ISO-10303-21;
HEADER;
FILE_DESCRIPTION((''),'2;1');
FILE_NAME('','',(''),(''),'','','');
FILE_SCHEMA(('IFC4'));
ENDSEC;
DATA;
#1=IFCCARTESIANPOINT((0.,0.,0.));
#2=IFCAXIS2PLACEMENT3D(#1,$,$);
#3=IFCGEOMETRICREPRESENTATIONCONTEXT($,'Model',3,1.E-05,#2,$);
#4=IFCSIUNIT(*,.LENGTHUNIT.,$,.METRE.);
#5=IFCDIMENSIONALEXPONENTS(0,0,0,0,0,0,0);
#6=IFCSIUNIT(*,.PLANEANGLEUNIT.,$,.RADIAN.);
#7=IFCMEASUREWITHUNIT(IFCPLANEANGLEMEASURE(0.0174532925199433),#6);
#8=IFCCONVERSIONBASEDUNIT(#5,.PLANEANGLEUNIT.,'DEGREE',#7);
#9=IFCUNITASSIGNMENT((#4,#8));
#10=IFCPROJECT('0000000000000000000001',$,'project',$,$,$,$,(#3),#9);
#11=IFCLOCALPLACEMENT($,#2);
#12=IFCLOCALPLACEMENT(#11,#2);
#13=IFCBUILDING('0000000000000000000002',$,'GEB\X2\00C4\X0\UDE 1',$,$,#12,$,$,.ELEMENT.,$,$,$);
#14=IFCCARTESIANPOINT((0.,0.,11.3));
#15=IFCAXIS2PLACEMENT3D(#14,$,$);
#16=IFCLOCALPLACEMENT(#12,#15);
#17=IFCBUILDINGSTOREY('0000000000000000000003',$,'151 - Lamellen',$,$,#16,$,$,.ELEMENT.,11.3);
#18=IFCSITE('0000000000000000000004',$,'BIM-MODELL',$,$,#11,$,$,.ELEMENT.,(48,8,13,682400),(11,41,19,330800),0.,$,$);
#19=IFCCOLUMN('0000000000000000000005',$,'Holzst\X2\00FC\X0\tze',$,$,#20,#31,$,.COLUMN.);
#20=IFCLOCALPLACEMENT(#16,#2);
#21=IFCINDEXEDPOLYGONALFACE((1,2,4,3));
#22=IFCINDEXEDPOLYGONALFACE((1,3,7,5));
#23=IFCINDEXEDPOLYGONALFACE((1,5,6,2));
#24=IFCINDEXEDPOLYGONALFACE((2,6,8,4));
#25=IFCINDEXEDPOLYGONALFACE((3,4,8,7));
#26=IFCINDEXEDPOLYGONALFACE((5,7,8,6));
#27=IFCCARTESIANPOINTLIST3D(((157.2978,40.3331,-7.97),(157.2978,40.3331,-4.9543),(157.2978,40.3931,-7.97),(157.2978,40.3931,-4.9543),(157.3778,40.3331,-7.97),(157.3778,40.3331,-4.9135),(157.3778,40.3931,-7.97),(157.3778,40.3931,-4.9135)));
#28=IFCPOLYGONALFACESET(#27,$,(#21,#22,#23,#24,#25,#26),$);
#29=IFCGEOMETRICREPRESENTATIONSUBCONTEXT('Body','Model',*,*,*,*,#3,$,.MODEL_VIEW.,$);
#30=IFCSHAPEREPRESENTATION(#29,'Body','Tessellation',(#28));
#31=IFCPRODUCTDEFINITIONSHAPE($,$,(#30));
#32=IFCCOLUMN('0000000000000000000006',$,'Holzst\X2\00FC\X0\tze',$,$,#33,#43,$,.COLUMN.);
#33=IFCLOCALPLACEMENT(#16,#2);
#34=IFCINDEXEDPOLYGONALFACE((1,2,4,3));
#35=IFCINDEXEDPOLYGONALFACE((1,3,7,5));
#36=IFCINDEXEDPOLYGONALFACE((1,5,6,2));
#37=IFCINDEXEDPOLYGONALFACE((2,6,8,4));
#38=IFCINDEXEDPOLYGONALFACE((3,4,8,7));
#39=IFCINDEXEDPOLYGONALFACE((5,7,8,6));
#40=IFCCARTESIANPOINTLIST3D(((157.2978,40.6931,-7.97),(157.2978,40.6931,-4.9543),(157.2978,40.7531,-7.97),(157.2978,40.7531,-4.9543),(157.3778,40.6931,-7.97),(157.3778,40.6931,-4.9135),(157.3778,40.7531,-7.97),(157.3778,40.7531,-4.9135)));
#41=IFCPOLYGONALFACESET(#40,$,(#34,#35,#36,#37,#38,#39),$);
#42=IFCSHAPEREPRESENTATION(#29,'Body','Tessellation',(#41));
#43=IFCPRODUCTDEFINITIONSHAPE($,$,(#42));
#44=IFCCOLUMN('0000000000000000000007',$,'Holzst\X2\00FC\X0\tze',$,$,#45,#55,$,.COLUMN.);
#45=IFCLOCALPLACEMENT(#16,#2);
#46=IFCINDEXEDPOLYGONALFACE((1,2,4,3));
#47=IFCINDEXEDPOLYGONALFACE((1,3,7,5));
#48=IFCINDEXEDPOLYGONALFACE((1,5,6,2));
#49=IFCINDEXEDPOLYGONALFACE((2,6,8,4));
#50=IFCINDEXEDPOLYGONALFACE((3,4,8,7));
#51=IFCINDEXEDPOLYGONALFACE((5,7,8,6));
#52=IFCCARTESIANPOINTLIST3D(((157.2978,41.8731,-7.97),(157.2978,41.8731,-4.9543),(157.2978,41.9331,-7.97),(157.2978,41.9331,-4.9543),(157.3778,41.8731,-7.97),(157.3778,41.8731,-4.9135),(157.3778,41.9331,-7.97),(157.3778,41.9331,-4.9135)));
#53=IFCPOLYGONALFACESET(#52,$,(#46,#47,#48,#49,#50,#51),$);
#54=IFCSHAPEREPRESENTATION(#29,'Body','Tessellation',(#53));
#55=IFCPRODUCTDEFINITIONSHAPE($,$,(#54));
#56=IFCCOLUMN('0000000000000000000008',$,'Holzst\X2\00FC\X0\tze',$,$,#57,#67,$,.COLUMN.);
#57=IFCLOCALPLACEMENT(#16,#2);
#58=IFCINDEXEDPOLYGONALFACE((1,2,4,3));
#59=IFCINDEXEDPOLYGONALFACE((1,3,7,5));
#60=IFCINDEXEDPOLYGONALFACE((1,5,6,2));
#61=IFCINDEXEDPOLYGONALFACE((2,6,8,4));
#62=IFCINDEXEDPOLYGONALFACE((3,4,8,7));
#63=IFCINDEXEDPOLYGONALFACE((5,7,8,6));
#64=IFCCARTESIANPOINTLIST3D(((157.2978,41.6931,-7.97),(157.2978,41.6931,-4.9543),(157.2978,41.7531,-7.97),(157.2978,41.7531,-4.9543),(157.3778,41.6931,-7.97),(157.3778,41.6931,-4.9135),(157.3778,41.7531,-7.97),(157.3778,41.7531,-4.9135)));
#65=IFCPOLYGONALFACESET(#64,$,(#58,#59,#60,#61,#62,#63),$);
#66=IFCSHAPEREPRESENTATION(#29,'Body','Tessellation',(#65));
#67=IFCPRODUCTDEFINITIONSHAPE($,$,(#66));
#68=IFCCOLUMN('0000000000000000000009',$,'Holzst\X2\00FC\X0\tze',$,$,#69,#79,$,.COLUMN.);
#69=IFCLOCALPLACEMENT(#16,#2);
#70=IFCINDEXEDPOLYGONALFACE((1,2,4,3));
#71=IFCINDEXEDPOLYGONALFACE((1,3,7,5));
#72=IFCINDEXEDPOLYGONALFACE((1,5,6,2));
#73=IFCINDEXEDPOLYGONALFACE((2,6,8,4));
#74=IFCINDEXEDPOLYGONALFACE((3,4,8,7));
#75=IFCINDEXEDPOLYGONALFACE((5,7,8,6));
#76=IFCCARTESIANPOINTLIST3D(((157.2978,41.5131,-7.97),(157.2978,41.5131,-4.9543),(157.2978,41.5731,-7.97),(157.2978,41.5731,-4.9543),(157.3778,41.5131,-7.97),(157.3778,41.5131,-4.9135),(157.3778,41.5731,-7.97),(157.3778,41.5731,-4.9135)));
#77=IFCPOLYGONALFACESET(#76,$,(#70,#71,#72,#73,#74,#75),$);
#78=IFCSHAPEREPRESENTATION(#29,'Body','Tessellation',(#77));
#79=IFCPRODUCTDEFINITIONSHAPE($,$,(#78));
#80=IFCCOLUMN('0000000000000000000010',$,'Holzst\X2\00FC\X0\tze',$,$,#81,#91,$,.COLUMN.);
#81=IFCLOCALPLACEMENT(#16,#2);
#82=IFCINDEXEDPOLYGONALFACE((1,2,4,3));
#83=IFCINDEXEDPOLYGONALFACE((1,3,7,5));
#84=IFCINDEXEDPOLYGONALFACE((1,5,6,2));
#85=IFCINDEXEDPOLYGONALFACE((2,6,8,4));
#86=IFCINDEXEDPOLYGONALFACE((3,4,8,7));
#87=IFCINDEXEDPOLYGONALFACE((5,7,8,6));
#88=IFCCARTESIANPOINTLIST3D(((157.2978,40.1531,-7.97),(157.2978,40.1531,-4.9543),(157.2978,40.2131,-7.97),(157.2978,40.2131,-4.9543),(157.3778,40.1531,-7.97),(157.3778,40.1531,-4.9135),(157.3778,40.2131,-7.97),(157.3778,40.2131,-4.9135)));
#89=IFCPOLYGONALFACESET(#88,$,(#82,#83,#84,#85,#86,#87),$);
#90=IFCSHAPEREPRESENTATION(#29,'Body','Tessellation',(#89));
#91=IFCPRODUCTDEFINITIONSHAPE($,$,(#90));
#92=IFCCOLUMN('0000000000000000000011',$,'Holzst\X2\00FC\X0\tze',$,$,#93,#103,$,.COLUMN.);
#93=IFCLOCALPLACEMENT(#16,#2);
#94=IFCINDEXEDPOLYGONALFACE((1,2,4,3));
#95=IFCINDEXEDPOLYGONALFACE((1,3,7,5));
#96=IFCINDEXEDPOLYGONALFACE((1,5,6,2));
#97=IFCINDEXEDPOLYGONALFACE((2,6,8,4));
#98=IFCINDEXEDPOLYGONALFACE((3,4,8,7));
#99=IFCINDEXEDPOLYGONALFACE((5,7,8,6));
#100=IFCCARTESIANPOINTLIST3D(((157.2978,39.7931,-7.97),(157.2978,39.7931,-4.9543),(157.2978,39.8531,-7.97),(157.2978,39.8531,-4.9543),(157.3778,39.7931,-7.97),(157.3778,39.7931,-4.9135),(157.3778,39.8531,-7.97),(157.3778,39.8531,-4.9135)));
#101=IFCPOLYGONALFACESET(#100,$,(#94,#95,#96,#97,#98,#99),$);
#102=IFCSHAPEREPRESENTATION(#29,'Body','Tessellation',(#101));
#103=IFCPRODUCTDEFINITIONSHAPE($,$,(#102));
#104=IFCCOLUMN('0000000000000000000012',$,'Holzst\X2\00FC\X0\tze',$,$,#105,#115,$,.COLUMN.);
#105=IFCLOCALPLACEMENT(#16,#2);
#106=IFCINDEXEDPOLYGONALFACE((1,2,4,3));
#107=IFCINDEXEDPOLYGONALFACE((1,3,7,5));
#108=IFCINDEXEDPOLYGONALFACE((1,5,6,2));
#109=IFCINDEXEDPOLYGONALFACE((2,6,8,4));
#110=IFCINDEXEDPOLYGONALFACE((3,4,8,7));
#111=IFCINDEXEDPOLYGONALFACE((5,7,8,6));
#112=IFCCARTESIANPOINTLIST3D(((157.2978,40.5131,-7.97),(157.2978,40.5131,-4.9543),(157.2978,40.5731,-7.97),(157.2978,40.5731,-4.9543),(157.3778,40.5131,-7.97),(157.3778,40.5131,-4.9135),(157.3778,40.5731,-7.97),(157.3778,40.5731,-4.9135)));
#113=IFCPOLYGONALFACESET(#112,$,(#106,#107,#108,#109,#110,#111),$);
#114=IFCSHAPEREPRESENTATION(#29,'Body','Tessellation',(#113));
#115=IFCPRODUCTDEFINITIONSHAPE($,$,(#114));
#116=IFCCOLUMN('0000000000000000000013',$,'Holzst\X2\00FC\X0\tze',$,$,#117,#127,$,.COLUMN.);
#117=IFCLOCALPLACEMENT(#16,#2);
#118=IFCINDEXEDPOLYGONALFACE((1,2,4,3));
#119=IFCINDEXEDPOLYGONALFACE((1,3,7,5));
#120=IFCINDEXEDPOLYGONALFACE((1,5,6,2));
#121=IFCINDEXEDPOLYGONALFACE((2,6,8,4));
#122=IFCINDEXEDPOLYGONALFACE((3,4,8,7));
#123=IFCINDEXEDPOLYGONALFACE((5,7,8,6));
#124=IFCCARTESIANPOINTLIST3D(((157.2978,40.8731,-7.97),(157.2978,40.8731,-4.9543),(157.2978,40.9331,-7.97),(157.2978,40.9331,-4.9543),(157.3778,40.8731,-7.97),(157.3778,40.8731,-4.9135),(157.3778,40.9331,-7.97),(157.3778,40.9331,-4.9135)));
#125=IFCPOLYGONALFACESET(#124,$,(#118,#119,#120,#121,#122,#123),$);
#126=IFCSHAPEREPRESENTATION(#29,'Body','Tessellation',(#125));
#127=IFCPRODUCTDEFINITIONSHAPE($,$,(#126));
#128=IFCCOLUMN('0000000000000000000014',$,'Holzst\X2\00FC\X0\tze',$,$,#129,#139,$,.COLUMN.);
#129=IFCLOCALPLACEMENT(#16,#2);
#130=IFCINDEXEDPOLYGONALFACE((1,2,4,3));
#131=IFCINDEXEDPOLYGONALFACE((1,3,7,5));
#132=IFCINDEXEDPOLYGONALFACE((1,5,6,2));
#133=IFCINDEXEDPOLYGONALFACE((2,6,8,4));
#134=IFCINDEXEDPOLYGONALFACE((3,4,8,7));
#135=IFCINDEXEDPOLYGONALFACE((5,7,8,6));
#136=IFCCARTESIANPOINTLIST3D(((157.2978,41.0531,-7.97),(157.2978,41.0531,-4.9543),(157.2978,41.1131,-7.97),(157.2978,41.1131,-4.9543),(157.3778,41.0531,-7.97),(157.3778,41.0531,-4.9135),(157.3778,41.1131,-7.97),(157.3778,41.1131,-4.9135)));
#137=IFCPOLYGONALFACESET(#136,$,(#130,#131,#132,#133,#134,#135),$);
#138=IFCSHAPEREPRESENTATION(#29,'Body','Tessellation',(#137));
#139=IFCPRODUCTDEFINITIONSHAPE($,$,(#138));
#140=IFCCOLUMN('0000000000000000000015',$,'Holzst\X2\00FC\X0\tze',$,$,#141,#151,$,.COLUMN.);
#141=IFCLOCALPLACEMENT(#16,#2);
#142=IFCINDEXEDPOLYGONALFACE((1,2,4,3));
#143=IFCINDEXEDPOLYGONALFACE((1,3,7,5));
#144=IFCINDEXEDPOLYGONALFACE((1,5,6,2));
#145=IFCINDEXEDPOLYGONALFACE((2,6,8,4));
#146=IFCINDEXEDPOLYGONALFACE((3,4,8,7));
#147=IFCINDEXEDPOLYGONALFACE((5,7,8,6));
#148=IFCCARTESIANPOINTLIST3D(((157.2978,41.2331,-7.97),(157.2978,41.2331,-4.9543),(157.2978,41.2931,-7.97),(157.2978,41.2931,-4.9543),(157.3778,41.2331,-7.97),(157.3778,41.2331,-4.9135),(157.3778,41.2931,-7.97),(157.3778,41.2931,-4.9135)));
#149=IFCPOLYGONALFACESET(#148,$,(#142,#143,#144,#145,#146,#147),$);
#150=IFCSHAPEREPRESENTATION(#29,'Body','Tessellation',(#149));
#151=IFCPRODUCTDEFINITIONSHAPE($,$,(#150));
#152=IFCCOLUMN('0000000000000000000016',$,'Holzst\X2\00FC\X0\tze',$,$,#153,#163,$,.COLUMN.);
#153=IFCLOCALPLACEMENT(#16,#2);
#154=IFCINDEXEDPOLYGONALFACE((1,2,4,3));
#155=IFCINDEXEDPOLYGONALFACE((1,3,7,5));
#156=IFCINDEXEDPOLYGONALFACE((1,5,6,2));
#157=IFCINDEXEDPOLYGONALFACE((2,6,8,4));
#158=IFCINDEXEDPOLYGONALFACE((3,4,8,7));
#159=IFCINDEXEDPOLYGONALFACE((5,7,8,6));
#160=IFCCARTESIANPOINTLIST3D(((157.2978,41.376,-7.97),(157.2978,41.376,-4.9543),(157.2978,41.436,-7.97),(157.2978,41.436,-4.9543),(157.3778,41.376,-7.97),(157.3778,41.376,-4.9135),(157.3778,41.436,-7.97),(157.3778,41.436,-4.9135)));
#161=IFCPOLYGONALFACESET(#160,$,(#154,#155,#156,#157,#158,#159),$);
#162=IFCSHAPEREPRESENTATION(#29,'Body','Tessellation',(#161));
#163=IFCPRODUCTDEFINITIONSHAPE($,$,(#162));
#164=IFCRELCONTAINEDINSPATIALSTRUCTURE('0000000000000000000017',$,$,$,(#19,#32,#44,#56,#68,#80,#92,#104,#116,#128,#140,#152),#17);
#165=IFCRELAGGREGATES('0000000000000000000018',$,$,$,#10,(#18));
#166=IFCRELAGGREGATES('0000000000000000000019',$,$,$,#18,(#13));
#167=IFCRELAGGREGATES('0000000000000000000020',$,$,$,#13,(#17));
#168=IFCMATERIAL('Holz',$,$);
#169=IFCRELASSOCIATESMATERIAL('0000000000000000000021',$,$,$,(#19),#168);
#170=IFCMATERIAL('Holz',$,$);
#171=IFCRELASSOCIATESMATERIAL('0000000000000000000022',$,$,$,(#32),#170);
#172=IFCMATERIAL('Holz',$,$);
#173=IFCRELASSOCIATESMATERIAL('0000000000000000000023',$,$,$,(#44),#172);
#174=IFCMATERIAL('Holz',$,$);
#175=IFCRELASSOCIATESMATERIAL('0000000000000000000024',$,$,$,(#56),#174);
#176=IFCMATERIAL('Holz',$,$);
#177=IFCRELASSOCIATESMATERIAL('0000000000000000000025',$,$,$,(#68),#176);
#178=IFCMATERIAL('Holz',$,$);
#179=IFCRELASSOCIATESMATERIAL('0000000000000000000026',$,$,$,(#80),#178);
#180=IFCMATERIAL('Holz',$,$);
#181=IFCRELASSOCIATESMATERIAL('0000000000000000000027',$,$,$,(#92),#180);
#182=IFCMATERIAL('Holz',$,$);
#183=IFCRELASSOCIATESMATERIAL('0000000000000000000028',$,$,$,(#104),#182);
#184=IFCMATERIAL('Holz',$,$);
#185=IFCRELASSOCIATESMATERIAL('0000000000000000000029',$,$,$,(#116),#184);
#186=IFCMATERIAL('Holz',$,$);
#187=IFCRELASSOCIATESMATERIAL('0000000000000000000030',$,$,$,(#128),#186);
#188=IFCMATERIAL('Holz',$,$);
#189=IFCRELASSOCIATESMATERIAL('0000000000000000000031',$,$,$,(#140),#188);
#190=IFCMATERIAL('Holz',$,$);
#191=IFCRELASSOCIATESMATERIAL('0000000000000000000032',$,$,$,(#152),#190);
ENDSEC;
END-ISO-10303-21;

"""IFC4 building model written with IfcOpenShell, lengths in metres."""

from ifc_helpers import new_model, entity, si_unit, converted_unit, frame, frame_2d, origin, origin_with_axes, place, context, subcontext, project, spatial, rectangle, extrude, clip, halfspace, material, element, save


model = new_model("IFC4")

# Units and contexts
model_context = context("Model", 3, precision=1e-05, world=origin())
body_context = subcontext(model_context, "Body", "Model", "MODEL_VIEW")
ifc_project = project(units=[si_unit("LENGTHUNIT", "METRE"), converted_unit("PLANEANGLEUNIT", "DEGREE", entity("IfcPlaneAngleMeasure", 0.0174532925199433), si_unit("PLANEANGLEUNIT", "RADIAN"), dimensions=[0, 0, 0, 0, 0, 0, 0])], contexts=[model_context])

# Site, building, storey
site_placement = place(None, origin())
site = spatial("IfcSite", under=ifc_project, at=site_placement, Name="BIM-MODELL", CompositionType="ELEMENT", RefLatitude=(48, 8, 13, 682400), RefLongitude=(11, 41, 19, 330800), RefElevation=0.0)
building_placement = place(site_placement, origin())
building = spatial("IfcBuilding", under=site, at=building_placement, Name="GEBÄUDE 1", CompositionType="ELEMENT")
storey_placement = place(building_placement, frame((0.0, 0.0, 11.3)))
storey = spatial("IfcBuildingStorey", under=building, at=storey_placement, Name="151 - Lamellen", CompositionType="ELEMENT", Elevation=11.3)

# Columns
ifc_material_1 = material(Name="Holz")
column_1_placement = place(storey_placement, frame((157.3778, 40.3331, -7.97)))
element("IfcColumn", 1, at=column_1_placement, inside=storey, material=ifc_material_1, Name="Holzstütze", PredefinedType="COLUMN", context=body_context, shape_type="Clipping", body=[
    clip(extrude(rectangle(XDim=0.06, YDim=0.08, at=frame_2d((-0.04, 0.03), x_axis=(0.0, 1.0))), origin_with_axes(), (0.0, 0.0, 1.0), 3.0565), halfspace(frame((-0.04, 0.03, 3.0361), z_axis=(0.45399, 0.0, -0.891007), x_axis=(-0.891007, 0.0, -0.45399)), True)),
])
ifc_material_2 = material(Name="Holz")
column_2_placement = place(storey_placement, frame((157.3778, 40.6931, -7.97)))
element("IfcColumn", 2, at=column_2_placement, inside=storey, material=ifc_material_2, Name="Holzstütze", PredefinedType="COLUMN", context=body_context, shape_type="Clipping", body=[
    clip(extrude(rectangle(XDim=0.06, YDim=0.08, at=frame_2d((-0.04, 0.03), x_axis=(0.0, 1.0))), origin_with_axes(), (0.0, 0.0, 1.0), 3.0565), halfspace(frame((-0.04, 0.03, 3.0361), z_axis=(0.45399, 0.0, -0.891007), x_axis=(-0.891007, 0.0, -0.45399)), True)),
])
ifc_material_3 = material(Name="Holz")
column_3_placement = place(storey_placement, frame((157.3778, 41.8731, -7.97)))
element("IfcColumn", 3, at=column_3_placement, inside=storey, material=ifc_material_3, Name="Holzstütze", PredefinedType="COLUMN", context=body_context, shape_type="Clipping", body=[
    clip(extrude(rectangle(XDim=0.06, YDim=0.08, at=frame_2d((-0.04, 0.03), x_axis=(0.0, 1.0))), origin_with_axes(), (0.0, 0.0, 1.0), 3.0565), halfspace(frame((-0.04, 0.03, 3.0361), z_axis=(0.45399, 0.0, -0.891007), x_axis=(-0.891007, 0.0, -0.45399)), True)),
])
ifc_material_4 = material(Name="Holz")
column_4_placement = place(storey_placement, frame((157.3778, 41.6931, -7.97)))
element("IfcColumn", 4, at=column_4_placement, inside=storey, material=ifc_material_4, Name="Holzstütze", PredefinedType="COLUMN", context=body_context, shape_type="Clipping", body=[
    clip(extrude(rectangle(XDim=0.06, YDim=0.08, at=frame_2d((-0.04, 0.03), x_axis=(0.0, 1.0))), origin_with_axes(), (0.0, 0.0, 1.0), 3.0565), halfspace(frame((-0.04, 0.03, 3.0361), z_axis=(0.45399, 0.0, -0.891007), x_axis=(-0.891007, 0.0, -0.45399)), True)),
])
ifc_material_5 = material(Name="Holz")
column_5_placement = place(storey_placement, frame((157.3778, 41.5131, -7.97)))
element("IfcColumn", 5, at=column_5_placement, inside=storey, material=ifc_material_5, Name="Holzstütze", PredefinedType="COLUMN", context=body_context, shape_type="Clipping", body=[
    clip(extrude(rectangle(XDim=0.06, YDim=0.08, at=frame_2d((-0.04, 0.03), x_axis=(0.0, 1.0))), origin_with_axes(), (0.0, 0.0, 1.0), 3.0565), halfspace(frame((-0.04, 0.03, 3.0361), z_axis=(0.45399, 0.0, -0.891007), x_axis=(-0.891007, 0.0, -0.45399)), True)),
])
ifc_material_6 = material(Name="Holz")
column_6_placement = place(storey_placement, frame((157.3778, 40.1531, -7.97)))
element("IfcColumn", 6, at=column_6_placement, inside=storey, material=ifc_material_6, Name="Holzstütze", PredefinedType="COLUMN", context=body_context, shape_type="Clipping", body=[
    clip(extrude(rectangle(XDim=0.06, YDim=0.08, at=frame_2d((-0.04, 0.03), x_axis=(0.0, 1.0))), origin_with_axes(), (0.0, 0.0, 1.0), 3.0565), halfspace(frame((-0.04, 0.03, 3.0361), z_axis=(0.45399, 0.0, -0.891007), x_axis=(-0.891007, 0.0, -0.45399)), True)),
])
ifc_material_7 = material(Name="Holz")
column_7_placement = place(storey_placement, frame((157.3778, 39.7931, -7.97)))
element("IfcColumn", 7, at=column_7_placement, inside=storey, material=ifc_material_7, Name="Holzstütze", PredefinedType="COLUMN", context=body_context, shape_type="Clipping", body=[
    clip(extrude(rectangle(XDim=0.06, YDim=0.08, at=frame_2d((-0.04, 0.03), x_axis=(0.0, 1.0))), origin_with_axes(), (0.0, 0.0, 1.0), 3.0565), halfspace(frame((-0.04, 0.03, 3.0361), z_axis=(0.45399, 0.0, -0.891007), x_axis=(-0.891007, 0.0, -0.45399)), True)),
])
ifc_material_8 = material(Name="Holz")
column_8_placement = place(storey_placement, frame((157.3778, 40.5131, -7.97)))
element("IfcColumn", 8, at=column_8_placement, inside=storey, material=ifc_material_8, Name="Holzstütze", PredefinedType="COLUMN", context=body_context, shape_type="Clipping", body=[
    clip(extrude(rectangle(XDim=0.06, YDim=0.08, at=frame_2d((-0.04, 0.03), x_axis=(0.0, 1.0))), origin_with_axes(), (0.0, 0.0, 1.0), 3.0565), halfspace(frame((-0.04, 0.03, 3.0361), z_axis=(0.45399, 0.0, -0.891007), x_axis=(-0.891007, 0.0, -0.45399)), True)),
])
ifc_material_9 = material(Name="Holz")
column_9_placement = place(storey_placement, frame((157.3778, 40.8731, -7.97)))
element("IfcColumn", 9, at=column_9_placement, inside=storey, material=ifc_material_9, Name="Holzstütze", PredefinedType="COLUMN", context=body_context, shape_type="Clipping", body=[
    clip(extrude(rectangle(XDim=0.06, YDim=0.08, at=frame_2d((-0.04, 0.03), x_axis=(0.0, 1.0))), origin_with_axes(), (0.0, 0.0, 1.0), 3.0565), halfspace(frame((-0.04, 0.03, 3.0361), z_axis=(0.45399, 0.0, -0.891007), x_axis=(-0.891007, 0.0, -0.45399)), True)),
])
ifc_material_10 = material(Name="Holz")
column_10_placement = place(storey_placement, frame((157.3778, 41.0531, -7.97)))
element("IfcColumn", 10, at=column_10_placement, inside=storey, material=ifc_material_10, Name="Holzstütze", PredefinedType="COLUMN", context=body_context, shape_type="Clipping", body=[
    clip(extrude(rectangle(XDim=0.06, YDim=0.08, at=frame_2d((-0.04, 0.03), x_axis=(0.0, 1.0))), origin_with_axes(), (0.0, 0.0, 1.0), 3.0565), halfspace(frame((-0.04, 0.03, 3.0361), z_axis=(0.45399, 0.0, -0.891007), x_axis=(-0.891007, 0.0, -0.45399)), True)),
])
ifc_material_11 = material(Name="Holz")
column_11_placement = place(storey_placement, frame((157.3778, 41.2331, -7.97)))
element("IfcColumn", 11, at=column_11_placement, inside=storey, material=ifc_material_11, Name="Holzstütze", PredefinedType="COLUMN", context=body_context, shape_type="Clipping", body=[
    clip(extrude(rectangle(XDim=0.06, YDim=0.08, at=frame_2d((-0.04, 0.03), x_axis=(0.0, 1.0))), origin_with_axes(), (0.0, 0.0, 1.0), 3.0565), halfspace(frame((-0.04, 0.03, 3.0361), z_axis=(0.45399, 0.0, -0.891007), x_axis=(-0.891007, 0.0, -0.45399)), True)),
])
ifc_material_12 = material(Name="Holz")
column_12_placement = place(storey_placement, frame((157.3778, 41.376, -7.97)))
element("IfcColumn", 12, at=column_12_placement, inside=storey, material=ifc_material_12, Name="Holzstütze", PredefinedType="COLUMN", context=body_context, shape_type="Clipping", body=[
    clip(extrude(rectangle(XDim=0.06, YDim=0.08, at=frame_2d((-0.04, 0.03), x_axis=(0.0, 1.0))), origin_with_axes(), (0.0, 0.0, 1.0), 3.0565), halfspace(frame((-0.04, 0.03, 3.0361), z_axis=(0.45399, 0.0, -0.891007), x_axis=(-0.891007, 0.0, -0.45399)), True)),
])

save(model, "model.ifc")
